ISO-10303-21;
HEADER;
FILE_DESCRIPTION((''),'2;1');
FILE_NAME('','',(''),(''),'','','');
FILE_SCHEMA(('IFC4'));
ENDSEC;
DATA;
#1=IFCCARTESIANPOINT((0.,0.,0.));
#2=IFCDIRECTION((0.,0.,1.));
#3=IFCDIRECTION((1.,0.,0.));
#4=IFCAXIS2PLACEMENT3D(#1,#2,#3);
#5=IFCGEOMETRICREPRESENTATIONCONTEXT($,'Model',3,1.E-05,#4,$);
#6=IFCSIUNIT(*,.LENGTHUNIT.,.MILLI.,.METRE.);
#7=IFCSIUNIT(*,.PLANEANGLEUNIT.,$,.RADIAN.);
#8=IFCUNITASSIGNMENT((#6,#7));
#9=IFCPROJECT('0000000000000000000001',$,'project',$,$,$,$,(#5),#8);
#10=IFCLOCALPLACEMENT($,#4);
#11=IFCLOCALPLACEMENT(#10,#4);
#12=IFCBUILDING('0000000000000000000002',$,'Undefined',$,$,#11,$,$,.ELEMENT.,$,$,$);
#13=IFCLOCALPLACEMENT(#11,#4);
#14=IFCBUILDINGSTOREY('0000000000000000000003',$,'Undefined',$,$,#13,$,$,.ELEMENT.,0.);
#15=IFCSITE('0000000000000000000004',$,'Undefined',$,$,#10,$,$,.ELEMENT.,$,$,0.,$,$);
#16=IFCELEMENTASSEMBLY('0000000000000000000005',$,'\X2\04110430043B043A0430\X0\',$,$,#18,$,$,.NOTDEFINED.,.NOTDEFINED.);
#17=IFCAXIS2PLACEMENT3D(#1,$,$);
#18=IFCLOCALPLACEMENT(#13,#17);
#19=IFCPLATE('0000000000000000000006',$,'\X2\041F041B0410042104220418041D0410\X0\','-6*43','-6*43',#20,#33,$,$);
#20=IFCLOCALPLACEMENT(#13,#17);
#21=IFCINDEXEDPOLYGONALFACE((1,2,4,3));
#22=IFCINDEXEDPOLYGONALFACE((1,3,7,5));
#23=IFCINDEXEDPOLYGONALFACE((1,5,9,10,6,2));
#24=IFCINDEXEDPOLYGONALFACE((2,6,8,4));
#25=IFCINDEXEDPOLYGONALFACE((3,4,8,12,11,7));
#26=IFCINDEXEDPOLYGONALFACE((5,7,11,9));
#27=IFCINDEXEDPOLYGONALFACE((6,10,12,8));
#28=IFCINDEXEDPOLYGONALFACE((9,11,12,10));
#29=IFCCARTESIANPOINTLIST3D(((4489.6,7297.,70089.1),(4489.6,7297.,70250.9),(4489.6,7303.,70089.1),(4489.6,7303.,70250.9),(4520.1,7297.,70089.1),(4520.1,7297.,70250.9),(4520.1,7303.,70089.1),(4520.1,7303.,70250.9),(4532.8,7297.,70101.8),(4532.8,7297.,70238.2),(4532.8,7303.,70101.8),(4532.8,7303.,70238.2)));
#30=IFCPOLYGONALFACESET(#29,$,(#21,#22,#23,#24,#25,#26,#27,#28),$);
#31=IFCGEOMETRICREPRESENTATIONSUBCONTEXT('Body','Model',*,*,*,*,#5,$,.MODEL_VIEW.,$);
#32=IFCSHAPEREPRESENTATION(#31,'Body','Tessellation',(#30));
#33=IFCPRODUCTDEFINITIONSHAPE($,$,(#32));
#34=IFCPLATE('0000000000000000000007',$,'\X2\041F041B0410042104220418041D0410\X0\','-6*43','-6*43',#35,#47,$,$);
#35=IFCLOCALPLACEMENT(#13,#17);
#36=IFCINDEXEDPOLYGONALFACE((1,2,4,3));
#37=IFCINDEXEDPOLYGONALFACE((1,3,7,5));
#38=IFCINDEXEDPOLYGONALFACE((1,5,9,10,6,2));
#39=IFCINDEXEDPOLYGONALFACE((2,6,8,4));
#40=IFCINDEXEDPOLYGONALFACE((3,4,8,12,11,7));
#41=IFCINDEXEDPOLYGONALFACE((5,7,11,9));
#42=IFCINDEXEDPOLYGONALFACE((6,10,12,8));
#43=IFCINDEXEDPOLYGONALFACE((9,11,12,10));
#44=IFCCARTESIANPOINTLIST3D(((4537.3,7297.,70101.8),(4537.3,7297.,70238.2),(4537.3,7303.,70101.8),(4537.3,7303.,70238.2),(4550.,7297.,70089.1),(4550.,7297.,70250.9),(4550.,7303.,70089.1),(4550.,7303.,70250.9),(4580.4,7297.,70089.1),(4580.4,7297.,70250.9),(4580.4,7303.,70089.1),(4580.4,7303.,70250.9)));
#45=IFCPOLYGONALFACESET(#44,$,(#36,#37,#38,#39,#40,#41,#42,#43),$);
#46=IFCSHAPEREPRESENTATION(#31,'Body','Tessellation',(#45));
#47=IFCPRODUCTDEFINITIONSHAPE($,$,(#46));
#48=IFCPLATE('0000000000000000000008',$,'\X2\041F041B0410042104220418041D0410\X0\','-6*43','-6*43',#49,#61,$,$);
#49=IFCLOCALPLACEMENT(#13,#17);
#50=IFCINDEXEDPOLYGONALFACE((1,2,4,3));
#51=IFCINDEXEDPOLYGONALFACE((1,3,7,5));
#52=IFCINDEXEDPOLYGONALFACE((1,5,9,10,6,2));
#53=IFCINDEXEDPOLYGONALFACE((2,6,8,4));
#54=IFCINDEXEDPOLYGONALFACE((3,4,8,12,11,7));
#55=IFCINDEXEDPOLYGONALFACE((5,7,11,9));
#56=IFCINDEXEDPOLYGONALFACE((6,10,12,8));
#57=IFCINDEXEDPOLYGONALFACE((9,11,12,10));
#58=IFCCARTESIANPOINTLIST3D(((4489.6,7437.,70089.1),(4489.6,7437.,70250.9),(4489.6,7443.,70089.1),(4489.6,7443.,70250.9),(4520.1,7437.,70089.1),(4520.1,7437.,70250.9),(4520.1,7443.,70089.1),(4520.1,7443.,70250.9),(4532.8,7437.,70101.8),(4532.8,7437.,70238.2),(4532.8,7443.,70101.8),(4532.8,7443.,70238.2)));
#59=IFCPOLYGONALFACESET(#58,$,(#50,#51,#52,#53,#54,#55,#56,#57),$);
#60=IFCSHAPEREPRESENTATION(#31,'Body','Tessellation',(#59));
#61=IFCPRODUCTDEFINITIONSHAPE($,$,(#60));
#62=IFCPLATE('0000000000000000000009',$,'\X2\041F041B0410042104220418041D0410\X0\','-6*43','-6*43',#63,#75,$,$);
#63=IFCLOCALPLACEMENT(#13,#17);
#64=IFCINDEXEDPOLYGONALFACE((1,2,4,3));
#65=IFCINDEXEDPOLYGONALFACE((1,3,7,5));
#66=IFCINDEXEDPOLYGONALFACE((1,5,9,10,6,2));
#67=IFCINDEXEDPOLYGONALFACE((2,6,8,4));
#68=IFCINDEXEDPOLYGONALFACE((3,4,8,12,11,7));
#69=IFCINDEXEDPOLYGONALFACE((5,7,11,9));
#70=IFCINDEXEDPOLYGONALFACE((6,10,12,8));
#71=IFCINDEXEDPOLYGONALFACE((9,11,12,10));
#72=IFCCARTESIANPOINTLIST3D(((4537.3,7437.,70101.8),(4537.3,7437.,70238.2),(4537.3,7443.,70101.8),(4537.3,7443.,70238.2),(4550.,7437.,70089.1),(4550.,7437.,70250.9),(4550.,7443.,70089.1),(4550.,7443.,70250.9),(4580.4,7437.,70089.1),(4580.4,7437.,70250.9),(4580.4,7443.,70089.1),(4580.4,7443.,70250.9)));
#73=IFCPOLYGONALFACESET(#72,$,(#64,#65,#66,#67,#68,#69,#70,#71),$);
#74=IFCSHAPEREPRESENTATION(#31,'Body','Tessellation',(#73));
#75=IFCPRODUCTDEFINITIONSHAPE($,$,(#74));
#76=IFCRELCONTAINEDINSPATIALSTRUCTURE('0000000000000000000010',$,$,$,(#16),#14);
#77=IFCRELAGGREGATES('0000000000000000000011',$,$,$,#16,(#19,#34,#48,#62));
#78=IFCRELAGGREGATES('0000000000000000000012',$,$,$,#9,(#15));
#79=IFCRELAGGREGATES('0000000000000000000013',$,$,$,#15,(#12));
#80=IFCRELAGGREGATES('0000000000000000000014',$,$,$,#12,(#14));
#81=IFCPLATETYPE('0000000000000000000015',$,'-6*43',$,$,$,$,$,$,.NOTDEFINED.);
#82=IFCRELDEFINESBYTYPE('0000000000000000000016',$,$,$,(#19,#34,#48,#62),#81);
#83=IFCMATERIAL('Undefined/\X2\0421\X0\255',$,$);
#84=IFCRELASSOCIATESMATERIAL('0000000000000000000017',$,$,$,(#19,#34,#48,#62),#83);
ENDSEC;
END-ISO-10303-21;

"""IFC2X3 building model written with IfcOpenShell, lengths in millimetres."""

from ifc_helpers import new_model, si_unit, frame, origin_with_axes, place, context, subcontext, project, spatial, polyline, outline, extrude, material, type_object, element, aggregate, save


model = new_model("IFC2X3")

# Units and contexts
model_context = context("Model", 3, precision=1e-05, world=origin_with_axes())
body_context = subcontext(model_context, "Body", "Model", "MODEL_VIEW")
ifc_project = project(units=[si_unit("LENGTHUNIT", "METRE", prefix="MILLI"), si_unit("PLANEANGLEUNIT", "RADIAN")], contexts=[model_context])

# Site, building, storey
site_placement = place(None, origin_with_axes())
site = spatial("IfcSite", under=ifc_project, at=site_placement, Name="Undefined", CompositionType="ELEMENT", RefElevation=0.0)
building_placement = place(site_placement, origin_with_axes())
building = spatial("IfcBuilding", under=site, at=building_placement, Name="Undefined", CompositionType="ELEMENT")
storey_placement = place(building_placement, origin_with_axes())
storey = spatial("IfcBuildingStorey", under=building, at=storey_placement, Name="Undefined", CompositionType="ELEMENT", Elevation=0.0)

# Shared definitions
ifc_material_1 = material(Name="Undefined/С255")

# Element assembly, plates
assembly_1_placement = place(storey_placement, origin_with_axes())
assembly_1 = element("IfcElementAssembly", 1, at=assembly_1_placement, inside=storey, Name="Балка", AssemblyPlace="NOTDEFINED", PredefinedType="NOTDEFINED")
plate_type_1 = type_object("IfcPlateType", Name="-6*43", PredefinedType="NOTDEFINED")
plate_1_placement = place(assembly_1_placement, frame((4532.8, 7300.0, 70250.9), z_axis=(0.0, -1.0, 0.0), x_axis=(-1.0, 0.0, 0.0)))
plate_1 = element("IfcPlate", 2, at=plate_1_placement, type_object=plate_type_1, material=ifc_material_1, Name="ПЛАСТИНА", Description="-6*43", ObjectType="-6*43", context=body_context, shape_type="SweptSolid", body=[
    extrude(outline(polyline([(0.0, 12.7), (12.7, 0.0), (43.2, 0.0), (43.2, 161.8), (12.7, 161.8), (0.0, 149.1), (0.0, 12.7)])), frame((0.0, 0.0, -3.0), z_axis=(0.0, 0.0, 1.0), x_axis=(1.0, 0.0, 0.0)), (0.0, 0.0, 1.0), 6.0),
])
plate_2_placement = place(assembly_1_placement, frame((4580.4, 7300.0, 70250.9), z_axis=(0.0, -1.0, 0.0), x_axis=(-1.0, 0.0, 0.0)))
plate_2 = element("IfcPlate", 3, at=plate_2_placement, type_object=plate_type_1, material=ifc_material_1, Name="ПЛАСТИНА", Description="-6*43", ObjectType="-6*43", context=body_context, shape_type="SweptSolid", body=[
    extrude(outline(polyline([(0.0, 0.0), (30.5, 0.0), (43.2, 12.7), (43.2, 149.1), (30.5, 161.8), (0.0, 161.8), (0.0, 0.0)])), frame((0.0, 0.0, -3.0), z_axis=(0.0, 0.0, 1.0), x_axis=(1.0, 0.0, 0.0)), (0.0, 0.0, 1.0), 6.0),
])
plate_3_placement = place(assembly_1_placement, frame((4532.8, 7440.0, 70250.9), z_axis=(0.0, -1.0, 0.0), x_axis=(-1.0, 0.0, 0.0)))
plate_3 = element("IfcPlate", 4, at=plate_3_placement, type_object=plate_type_1, material=ifc_material_1, Name="ПЛАСТИНА", Description="-6*43", ObjectType="-6*43", context=body_context, shape_type="SweptSolid", body=[
    extrude(outline(polyline([(0.0, 12.7), (12.7, 0.0), (43.2, 0.0), (43.2, 161.8), (12.7, 161.8), (0.0, 149.1), (0.0, 12.7)])), frame((0.0, 0.0, -3.0), z_axis=(0.0, 0.0, 1.0), x_axis=(1.0, 0.0, 0.0)), (0.0, 0.0, 1.0), 6.0),
])
plate_4_placement = place(assembly_1_placement, frame((4580.4, 7440.0, 70250.9), z_axis=(0.0, -1.0, 0.0), x_axis=(-1.0, 0.0, 0.0)))
plate_4 = element("IfcPlate", 5, at=plate_4_placement, type_object=plate_type_1, material=ifc_material_1, Name="ПЛАСТИНА", Description="-6*43", ObjectType="-6*43", context=body_context, shape_type="SweptSolid", body=[
    extrude(outline(polyline([(0.0, 0.0), (30.5, 0.0), (43.2, 12.7), (43.2, 149.1), (30.5, 161.8), (0.0, 161.8), (0.0, 0.0)])), frame((0.0, 0.0, -3.0), z_axis=(0.0, 0.0, 1.0), x_axis=(1.0, 0.0, 0.0)), (0.0, 0.0, 1.0), 6.0),
])

aggregate(assembly_1, [plate_1, plate_2, plate_3, plate_4])

save(model, "model.ifc")
